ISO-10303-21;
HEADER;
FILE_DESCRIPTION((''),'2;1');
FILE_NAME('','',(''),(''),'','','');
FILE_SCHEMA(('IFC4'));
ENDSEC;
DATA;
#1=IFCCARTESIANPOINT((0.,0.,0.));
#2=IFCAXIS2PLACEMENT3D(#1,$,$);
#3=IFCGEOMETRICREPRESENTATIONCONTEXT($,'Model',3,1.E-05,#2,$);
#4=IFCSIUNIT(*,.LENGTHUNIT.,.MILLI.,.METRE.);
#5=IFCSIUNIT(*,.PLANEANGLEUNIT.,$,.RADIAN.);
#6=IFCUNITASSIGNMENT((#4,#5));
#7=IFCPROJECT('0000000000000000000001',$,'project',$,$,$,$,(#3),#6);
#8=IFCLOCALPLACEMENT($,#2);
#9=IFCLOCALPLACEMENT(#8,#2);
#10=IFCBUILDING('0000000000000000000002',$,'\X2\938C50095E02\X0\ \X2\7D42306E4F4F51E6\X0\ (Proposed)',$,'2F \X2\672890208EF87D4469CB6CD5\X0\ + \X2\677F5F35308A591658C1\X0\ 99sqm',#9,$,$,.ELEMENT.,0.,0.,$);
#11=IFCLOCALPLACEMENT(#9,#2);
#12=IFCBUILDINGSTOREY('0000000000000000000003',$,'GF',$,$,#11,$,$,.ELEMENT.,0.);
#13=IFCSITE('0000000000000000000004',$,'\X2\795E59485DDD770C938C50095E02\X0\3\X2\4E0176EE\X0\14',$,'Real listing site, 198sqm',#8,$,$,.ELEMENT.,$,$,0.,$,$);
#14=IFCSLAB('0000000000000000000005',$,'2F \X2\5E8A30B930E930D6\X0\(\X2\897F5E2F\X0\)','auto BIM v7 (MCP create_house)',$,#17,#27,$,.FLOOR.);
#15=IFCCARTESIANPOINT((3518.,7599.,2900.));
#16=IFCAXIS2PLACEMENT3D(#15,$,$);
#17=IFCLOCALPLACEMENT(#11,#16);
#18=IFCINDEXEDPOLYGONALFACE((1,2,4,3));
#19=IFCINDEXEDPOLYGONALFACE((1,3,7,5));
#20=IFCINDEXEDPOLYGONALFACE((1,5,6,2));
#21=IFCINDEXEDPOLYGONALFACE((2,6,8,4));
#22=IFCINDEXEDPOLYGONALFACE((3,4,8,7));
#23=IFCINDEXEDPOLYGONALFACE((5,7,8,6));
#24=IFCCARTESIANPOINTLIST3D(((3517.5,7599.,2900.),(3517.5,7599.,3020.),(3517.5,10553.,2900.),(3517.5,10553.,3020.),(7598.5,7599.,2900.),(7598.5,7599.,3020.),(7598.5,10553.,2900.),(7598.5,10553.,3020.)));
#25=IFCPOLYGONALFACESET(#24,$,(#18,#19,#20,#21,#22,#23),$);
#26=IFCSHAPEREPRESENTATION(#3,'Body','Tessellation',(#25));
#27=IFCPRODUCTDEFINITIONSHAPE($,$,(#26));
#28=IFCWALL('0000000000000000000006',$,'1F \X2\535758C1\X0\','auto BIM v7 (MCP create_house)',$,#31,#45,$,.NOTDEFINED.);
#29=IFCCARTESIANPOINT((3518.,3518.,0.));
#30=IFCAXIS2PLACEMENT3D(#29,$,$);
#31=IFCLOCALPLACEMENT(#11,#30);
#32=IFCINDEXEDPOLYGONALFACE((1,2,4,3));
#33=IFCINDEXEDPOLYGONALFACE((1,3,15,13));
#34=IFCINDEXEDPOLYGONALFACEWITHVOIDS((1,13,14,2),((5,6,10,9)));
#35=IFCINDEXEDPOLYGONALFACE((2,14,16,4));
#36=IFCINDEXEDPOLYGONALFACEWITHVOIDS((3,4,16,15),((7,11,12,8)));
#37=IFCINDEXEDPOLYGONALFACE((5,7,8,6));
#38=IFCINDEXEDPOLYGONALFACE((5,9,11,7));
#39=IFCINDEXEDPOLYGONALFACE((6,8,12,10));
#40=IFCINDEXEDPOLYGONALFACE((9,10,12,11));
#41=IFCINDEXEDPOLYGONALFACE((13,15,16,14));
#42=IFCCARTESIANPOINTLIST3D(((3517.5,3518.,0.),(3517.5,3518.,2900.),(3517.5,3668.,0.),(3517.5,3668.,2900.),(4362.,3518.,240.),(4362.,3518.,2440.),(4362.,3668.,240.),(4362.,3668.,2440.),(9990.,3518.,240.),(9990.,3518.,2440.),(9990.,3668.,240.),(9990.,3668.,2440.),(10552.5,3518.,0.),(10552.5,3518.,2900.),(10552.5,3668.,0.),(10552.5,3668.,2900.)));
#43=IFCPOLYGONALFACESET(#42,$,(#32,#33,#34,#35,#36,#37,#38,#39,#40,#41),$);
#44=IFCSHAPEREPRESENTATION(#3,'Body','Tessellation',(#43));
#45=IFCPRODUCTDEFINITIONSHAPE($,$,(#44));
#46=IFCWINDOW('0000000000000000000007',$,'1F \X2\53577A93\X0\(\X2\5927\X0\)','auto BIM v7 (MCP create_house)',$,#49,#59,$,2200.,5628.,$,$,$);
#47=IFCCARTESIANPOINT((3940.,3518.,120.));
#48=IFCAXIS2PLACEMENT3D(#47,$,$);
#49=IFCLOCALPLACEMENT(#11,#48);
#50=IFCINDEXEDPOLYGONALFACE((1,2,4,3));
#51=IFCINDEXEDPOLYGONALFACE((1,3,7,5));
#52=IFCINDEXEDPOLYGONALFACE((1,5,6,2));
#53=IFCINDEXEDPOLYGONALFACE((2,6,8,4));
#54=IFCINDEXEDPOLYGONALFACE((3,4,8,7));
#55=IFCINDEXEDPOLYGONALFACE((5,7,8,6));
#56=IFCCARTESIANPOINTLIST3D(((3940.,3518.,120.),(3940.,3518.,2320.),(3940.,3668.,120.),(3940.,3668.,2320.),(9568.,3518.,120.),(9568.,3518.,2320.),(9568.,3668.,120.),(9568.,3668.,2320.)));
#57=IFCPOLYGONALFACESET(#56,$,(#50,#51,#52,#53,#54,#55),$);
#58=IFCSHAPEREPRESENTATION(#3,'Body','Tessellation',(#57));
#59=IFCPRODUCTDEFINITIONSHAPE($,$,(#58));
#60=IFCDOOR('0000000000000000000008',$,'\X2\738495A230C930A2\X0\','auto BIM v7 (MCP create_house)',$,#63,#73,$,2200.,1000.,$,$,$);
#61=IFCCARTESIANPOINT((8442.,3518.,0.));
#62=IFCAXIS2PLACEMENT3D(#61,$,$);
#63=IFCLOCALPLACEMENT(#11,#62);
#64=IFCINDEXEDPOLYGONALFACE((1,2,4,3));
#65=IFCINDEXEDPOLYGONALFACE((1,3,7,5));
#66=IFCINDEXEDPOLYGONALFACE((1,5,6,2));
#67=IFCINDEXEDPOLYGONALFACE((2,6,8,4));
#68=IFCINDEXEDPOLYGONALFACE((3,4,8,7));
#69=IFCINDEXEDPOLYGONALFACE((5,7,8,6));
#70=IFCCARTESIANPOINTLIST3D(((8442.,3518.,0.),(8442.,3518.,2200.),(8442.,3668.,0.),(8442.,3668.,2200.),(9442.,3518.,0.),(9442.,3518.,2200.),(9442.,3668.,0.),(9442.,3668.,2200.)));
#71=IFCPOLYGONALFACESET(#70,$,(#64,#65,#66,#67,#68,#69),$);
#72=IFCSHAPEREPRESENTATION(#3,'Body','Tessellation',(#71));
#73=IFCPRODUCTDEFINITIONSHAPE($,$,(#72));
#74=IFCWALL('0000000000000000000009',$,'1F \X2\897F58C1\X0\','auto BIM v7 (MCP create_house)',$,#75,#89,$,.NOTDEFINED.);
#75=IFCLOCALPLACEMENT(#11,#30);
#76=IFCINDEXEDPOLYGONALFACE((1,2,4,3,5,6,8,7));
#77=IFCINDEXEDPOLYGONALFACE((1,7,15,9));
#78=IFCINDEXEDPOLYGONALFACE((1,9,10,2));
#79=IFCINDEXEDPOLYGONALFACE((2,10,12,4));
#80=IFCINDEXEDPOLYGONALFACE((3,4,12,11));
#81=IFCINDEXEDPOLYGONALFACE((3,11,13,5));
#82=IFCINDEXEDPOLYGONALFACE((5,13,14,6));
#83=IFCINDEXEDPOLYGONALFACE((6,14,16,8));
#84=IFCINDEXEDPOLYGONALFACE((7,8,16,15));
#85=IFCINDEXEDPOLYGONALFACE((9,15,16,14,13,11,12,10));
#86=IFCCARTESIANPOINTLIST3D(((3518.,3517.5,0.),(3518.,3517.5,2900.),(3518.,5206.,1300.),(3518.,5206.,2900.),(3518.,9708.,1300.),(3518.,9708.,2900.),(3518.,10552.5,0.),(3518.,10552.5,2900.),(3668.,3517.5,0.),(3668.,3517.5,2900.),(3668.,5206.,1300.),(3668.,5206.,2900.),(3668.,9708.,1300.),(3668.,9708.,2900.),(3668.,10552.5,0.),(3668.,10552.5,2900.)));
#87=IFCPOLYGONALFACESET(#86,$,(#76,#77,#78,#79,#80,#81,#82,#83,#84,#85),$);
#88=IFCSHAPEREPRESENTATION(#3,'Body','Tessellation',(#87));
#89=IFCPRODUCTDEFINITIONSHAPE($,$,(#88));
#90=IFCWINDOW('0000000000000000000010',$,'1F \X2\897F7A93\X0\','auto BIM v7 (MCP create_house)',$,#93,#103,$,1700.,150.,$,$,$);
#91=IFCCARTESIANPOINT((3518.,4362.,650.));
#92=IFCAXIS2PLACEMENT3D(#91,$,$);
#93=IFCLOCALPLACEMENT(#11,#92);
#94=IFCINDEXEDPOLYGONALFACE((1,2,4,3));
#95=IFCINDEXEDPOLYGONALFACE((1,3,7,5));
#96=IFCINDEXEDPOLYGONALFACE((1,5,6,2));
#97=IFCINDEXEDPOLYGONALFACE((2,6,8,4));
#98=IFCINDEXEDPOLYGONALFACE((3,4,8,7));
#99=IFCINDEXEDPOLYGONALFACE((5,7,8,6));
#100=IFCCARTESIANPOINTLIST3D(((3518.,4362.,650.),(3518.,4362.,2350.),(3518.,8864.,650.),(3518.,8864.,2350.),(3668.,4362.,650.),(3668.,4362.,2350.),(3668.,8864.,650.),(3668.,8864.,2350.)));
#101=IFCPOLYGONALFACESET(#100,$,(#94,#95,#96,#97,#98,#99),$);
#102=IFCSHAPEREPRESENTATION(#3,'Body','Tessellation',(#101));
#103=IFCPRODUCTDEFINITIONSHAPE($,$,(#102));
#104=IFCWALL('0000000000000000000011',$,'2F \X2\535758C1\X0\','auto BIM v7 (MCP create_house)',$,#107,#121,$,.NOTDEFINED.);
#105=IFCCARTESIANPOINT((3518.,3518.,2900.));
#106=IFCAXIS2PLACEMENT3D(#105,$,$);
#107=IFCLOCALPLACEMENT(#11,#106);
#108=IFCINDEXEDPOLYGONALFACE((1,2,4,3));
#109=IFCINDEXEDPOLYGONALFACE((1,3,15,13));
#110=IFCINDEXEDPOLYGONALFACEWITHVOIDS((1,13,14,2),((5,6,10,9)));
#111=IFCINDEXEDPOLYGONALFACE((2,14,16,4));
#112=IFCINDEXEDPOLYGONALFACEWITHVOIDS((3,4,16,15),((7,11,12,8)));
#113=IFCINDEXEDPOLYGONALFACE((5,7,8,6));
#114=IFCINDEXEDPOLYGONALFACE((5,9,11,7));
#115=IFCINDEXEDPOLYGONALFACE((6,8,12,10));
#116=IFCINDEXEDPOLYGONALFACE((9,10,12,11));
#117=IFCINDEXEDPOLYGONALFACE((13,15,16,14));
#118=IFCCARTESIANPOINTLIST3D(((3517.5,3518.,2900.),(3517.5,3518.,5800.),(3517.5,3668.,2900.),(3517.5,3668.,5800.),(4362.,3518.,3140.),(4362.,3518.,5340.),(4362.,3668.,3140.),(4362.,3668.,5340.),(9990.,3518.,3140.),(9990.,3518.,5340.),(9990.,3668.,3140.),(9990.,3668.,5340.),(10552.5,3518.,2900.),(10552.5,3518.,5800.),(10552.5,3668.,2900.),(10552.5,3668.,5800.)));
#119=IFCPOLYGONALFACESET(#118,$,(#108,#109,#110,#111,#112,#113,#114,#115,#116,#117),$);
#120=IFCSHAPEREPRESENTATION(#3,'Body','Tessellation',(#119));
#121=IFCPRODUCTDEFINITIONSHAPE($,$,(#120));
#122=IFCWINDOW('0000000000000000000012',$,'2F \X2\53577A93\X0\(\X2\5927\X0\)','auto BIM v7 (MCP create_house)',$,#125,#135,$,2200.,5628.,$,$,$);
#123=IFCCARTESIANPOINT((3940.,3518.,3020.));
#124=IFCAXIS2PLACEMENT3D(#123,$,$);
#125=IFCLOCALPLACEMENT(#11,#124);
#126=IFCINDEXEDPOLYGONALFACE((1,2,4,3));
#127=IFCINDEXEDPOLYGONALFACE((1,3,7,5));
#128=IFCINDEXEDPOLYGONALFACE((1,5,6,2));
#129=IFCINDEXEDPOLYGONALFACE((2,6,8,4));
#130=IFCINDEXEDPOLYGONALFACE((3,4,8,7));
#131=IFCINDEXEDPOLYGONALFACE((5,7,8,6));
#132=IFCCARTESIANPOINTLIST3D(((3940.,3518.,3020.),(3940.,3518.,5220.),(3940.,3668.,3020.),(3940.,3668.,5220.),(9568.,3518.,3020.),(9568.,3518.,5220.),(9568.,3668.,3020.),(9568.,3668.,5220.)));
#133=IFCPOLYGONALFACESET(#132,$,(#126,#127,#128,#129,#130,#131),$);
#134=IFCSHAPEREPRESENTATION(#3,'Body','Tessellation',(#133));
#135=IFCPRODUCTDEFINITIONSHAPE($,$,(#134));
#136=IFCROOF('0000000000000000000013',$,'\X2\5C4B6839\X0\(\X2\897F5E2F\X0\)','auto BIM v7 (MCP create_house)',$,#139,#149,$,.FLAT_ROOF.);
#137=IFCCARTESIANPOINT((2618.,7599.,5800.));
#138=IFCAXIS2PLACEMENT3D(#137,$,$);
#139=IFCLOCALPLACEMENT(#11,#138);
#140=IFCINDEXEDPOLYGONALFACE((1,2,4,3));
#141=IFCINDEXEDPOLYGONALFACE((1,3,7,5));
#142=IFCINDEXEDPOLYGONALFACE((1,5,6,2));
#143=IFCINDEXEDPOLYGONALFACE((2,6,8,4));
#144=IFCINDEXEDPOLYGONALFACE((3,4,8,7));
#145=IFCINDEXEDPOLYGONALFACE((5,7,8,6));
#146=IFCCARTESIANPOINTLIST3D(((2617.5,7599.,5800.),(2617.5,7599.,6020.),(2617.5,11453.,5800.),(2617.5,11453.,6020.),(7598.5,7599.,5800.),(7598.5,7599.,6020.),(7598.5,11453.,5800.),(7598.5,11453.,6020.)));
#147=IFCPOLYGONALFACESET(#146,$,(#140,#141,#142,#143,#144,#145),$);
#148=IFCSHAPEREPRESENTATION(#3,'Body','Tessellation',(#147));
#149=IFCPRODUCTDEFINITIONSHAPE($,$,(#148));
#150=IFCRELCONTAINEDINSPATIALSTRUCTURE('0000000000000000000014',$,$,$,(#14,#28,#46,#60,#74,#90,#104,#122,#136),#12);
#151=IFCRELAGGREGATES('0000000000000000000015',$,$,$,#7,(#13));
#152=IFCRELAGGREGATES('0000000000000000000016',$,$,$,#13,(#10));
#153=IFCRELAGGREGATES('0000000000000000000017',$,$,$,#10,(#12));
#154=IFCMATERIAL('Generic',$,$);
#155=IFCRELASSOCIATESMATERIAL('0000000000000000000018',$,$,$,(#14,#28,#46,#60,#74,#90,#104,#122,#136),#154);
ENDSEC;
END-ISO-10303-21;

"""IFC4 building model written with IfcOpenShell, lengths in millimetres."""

from ifc_helpers import new_model, si_unit, frame, frame_2d, origin, place, context, project, spatial, rectangle, extrude, material, element, fill, save


model = new_model("IFC4")

# Units and contexts
model_context = context("Model", 3, precision=1e-05, world=origin())
ifc_project = project(units=[si_unit("LENGTHUNIT", "METRE", prefix="MILLI"), si_unit("PLANEANGLEUNIT", "RADIAN")], contexts=[model_context])

# Site, building, storey
site_placement = place(None, origin())
site = spatial("IfcSite", under=ifc_project, at=site_placement, Name="神奈川県鎌倉市3丁目14", ObjectType="Real listing site, 198sqm", CompositionType="ELEMENT", RefElevation=0.0)
building_placement = place(site_placement, origin())
building = spatial("IfcBuilding", under=site, at=building_placement, Name="鎌倉市 終の住処 (Proposed)", ObjectType="2F 木造軸組構法 + 板張り外壁 99sqm", CompositionType="ELEMENT", ElevationOfRefHeight=0.0, ElevationOfTerrain=0.0)
storey_placement = place(building_placement, origin())
storey = spatial("IfcBuildingStorey", under=building, at=storey_placement, Name="GF", CompositionType="ELEMENT", Elevation=0.0)

# Slab
ifc_material = material(Name="Generic")
slab_1_placement = place(storey_placement, frame((3518.0, 7599.0, 2900.0)))
element("IfcSlab", 1, at=slab_1_placement, inside=storey, material=ifc_material, Name="2F 床スラブ(西帯)", Description="auto BIM v7 (MCP create_house)", PredefinedType="FLOOR", context=model_context, shape_type="SweptSolid", body=[
    extrude(rectangle(XDim=4081.0, YDim=2954.0, at=frame_2d((2040.0, 1477.0))), frame((3518.0, 7599.0, 2900.0)), (0.0, 0.0, 1.0), 120.0),
])

# Wall, openings, window, door
wall_1_placement = place(storey_placement, frame((3518.0, 3518.0, 0.0)))
wall_1 = element("IfcWall", 2, at=wall_1_placement, inside=storey, material=ifc_material, Name="1F 南壁", Description="auto BIM v7 (MCP create_house)", PredefinedType="NOTDEFINED", context=model_context, shape_type="SweptSolid", body=[
    extrude(rectangle(XDim=7035.0, YDim=150.0, at=frame_2d((3517.0, 75.0))), frame((3518.0, 3518.0, 0.0)), (0.0, 0.0, 1.0), 2900.0),
])
opening_1_placement = place(storey_placement, frame((3940.0, 3518.0, 120.0)))
opening_1 = element("IfcOpeningElement", 3, at=opening_1_placement, cuts=wall_1, PredefinedType="NOTDEFINED", context=model_context, shape_type="SweptSolid", body=[
    extrude(rectangle(XDim=5628.0, YDim=150.0, at=frame_2d((2814.0, 75.0))), frame((3940.0, 3518.0, 120.0)), (0.0, 0.0, 1.0), 2200.0),
])
opening_2_placement = place(storey_placement, frame((8442.0, 3518.0, 0.0)))
opening_2 = element("IfcOpeningElement", 4, at=opening_2_placement, cuts=wall_1, PredefinedType="NOTDEFINED", context=model_context, shape_type="SweptSolid", body=[
    extrude(rectangle(XDim=1000.0, YDim=150.0, at=frame_2d((500.0, 75.0))), frame((8442.0, 3518.0, 0.0)), (0.0, 0.0, 1.0), 2200.0),
])
window_1_placement = place(storey_placement, frame((3940.0, 3518.0, 120.0)))
window_1 = element("IfcWindow", 5, at=window_1_placement, inside=storey, material=ifc_material, Name="1F 南窓(大)", Description="auto BIM v7 (MCP create_house)", OverallHeight=2200.0, OverallWidth=5628.0, context=model_context, shape_type="SweptSolid", body=[
    extrude(rectangle(XDim=5628.0, YDim=150.0, at=frame_2d((2814.0, 75.0))), frame((3940.0, 3518.0, 120.0)), (0.0, 0.0, 1.0), 2200.0),
])
fill(opening_1, window_1)
door_placement = place(storey_placement, frame((8442.0, 3518.0, 0.0)))
door = element("IfcDoor", 6, at=door_placement, inside=storey, material=ifc_material, Name="玄関ドア", Description="auto BIM v7 (MCP create_house)", OverallHeight=2200.0, OverallWidth=1000.0, context=model_context, shape_type="SweptSolid", body=[
    extrude(rectangle(XDim=1000.0, YDim=150.0, at=frame_2d((500.0, 75.0))), frame((8442.0, 3518.0, 0.0)), (0.0, 0.0, 1.0), 2200.0),
])
fill(opening_2, door)

# Wall, opening, window
wall_2_placement = place(storey_placement, frame((3518.0, 3518.0, 0.0)))
wall_2 = element("IfcWall", 7, at=wall_2_placement, inside=storey, material=ifc_material, Name="1F 西壁", Description="auto BIM v7 (MCP create_house)", PredefinedType="NOTDEFINED", context=model_context, shape_type="SweptSolid", body=[
    extrude(rectangle(XDim=150.0, YDim=7035.0, at=frame_2d((75.0, 3517.0))), frame((3518.0, 3518.0, 0.0)), (0.0, 0.0, 1.0), 2900.0),
])
opening_3_placement = place(storey_placement, frame((3518.0, 4362.0, 650.0)))
opening_3 = element("IfcOpeningElement", 8, at=opening_3_placement, cuts=wall_2, PredefinedType="NOTDEFINED", context=model_context, shape_type="SweptSolid", body=[
    extrude(rectangle(XDim=150.0, YDim=4502.0, at=frame_2d((75.0, 2251.0))), frame((3518.0, 4362.0, 650.0)), (0.0, 0.0, 1.0), 1700.0),
])
window_2_placement = place(storey_placement, frame((3518.0, 4362.0, 650.0)))
window_2 = element("IfcWindow", 9, at=window_2_placement, inside=storey, material=ifc_material, Name="1F 西窓", Description="auto BIM v7 (MCP create_house)", OverallHeight=1700.0, OverallWidth=150.0, context=model_context, shape_type="SweptSolid", body=[
    extrude(rectangle(XDim=150.0, YDim=4502.0, at=frame_2d((75.0, 2251.0))), frame((3518.0, 4362.0, 650.0)), (0.0, 0.0, 1.0), 1700.0),
])
fill(opening_3, window_2)

# Wall, opening, window
wall_3_placement = place(storey_placement, frame((3518.0, 3518.0, 2900.0)))
wall_3 = element("IfcWall", 10, at=wall_3_placement, inside=storey, material=ifc_material, Name="2F 南壁", Description="auto BIM v7 (MCP create_house)", PredefinedType="NOTDEFINED", context=model_context, shape_type="SweptSolid", body=[
    extrude(rectangle(XDim=7035.0, YDim=150.0, at=frame_2d((3517.0, 75.0))), frame((3518.0, 3518.0, 2900.0)), (0.0, 0.0, 1.0), 2900.0),
])
opening_4_placement = place(storey_placement, frame((3940.0, 3518.0, 3020.0)))
opening_4 = element("IfcOpeningElement", 11, at=opening_4_placement, cuts=wall_3, PredefinedType="NOTDEFINED", context=model_context, shape_type="SweptSolid", body=[
    extrude(rectangle(XDim=5628.0, YDim=150.0, at=frame_2d((2814.0, 75.0))), frame((3940.0, 3518.0, 3020.0)), (0.0, 0.0, 1.0), 2200.0),
])
window_3_placement = place(storey_placement, frame((3940.0, 3518.0, 3020.0)))
window_3 = element("IfcWindow", 12, at=window_3_placement, inside=storey, material=ifc_material, Name="2F 南窓(大)", Description="auto BIM v7 (MCP create_house)", OverallHeight=2200.0, OverallWidth=5628.0, context=model_context, shape_type="SweptSolid", body=[
    extrude(rectangle(XDim=5628.0, YDim=150.0, at=frame_2d((2814.0, 75.0))), frame((3940.0, 3518.0, 3020.0)), (0.0, 0.0, 1.0), 2200.0),
])
fill(opening_4, window_3)

# Roof
roof_1_placement = place(storey_placement, frame((2618.0, 7599.0, 5800.0)))
element("IfcRoof", 13, at=roof_1_placement, inside=storey, material=ifc_material, Name="屋根(西帯)", Description="auto BIM v7 (MCP create_house)", PredefinedType="FLAT_ROOF", context=model_context, shape_type="SweptSolid", body=[
    extrude(rectangle(XDim=4981.0, YDim=3854.0, at=frame_2d((2490.0, 1927.0))), frame((2618.0, 7599.0, 5800.0)), (0.0, 0.0, 1.0), 220.0),
])

save(model, "model.ifc")
